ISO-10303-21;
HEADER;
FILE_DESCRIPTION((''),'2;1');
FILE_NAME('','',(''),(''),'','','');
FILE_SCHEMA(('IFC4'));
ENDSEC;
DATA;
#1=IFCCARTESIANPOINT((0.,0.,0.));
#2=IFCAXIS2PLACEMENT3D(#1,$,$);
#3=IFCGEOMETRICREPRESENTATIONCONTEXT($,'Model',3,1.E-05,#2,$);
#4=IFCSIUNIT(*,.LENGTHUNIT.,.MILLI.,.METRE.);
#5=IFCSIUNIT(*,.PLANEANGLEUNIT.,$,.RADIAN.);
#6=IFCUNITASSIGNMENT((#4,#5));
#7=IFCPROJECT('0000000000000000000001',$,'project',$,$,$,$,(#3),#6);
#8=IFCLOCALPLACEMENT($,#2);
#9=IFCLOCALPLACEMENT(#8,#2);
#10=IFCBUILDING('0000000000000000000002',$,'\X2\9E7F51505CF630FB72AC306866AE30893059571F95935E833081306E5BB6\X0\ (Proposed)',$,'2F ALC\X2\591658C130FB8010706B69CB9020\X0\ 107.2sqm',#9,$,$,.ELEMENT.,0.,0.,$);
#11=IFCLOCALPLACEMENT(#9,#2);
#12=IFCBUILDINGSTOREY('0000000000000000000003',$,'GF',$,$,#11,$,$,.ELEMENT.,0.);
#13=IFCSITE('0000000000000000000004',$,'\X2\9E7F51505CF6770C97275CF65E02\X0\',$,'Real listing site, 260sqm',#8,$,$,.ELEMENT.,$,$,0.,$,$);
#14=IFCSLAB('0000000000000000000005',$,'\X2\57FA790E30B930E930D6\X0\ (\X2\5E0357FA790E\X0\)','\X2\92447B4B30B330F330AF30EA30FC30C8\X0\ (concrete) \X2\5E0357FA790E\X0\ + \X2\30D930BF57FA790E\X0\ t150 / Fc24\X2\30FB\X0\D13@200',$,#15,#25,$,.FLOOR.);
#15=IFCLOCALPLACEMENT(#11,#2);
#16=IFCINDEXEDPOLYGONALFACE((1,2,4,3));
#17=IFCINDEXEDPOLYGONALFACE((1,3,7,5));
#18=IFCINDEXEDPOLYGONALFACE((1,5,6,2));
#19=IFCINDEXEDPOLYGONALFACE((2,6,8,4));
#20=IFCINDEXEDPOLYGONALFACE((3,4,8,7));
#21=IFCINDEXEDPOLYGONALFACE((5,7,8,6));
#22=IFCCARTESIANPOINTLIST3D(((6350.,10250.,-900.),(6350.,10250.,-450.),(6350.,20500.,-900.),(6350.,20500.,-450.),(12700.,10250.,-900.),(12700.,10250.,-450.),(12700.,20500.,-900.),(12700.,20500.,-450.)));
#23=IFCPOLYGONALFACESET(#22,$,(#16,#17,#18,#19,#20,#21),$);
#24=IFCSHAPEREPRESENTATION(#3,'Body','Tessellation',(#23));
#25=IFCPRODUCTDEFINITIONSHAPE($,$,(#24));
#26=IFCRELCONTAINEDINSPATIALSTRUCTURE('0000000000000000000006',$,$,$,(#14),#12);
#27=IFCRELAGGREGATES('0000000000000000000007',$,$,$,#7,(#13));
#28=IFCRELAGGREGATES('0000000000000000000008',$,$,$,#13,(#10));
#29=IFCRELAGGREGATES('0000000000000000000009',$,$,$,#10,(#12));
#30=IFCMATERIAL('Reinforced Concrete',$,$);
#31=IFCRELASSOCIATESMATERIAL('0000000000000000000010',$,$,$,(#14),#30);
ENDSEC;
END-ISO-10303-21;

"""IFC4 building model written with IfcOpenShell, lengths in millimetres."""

from ifc_helpers import new_model, si_unit, frame, frame_2d, origin, place, context, project, spatial, rectangle, extrude, material, element, save


model = new_model("IFC4")

# Units and contexts
model_context = context("Model", 3, precision=1e-05, world=origin())
ifc_project = project(units=[si_unit("LENGTHUNIT", "METRE", prefix="MILLI"), si_unit("PLANEANGLEUNIT", "RADIAN")], contexts=[model_context])

# Site, building, storey
site_placement = place(None, origin())
site = spatial("IfcSite", under=ifc_project, at=site_placement, Name="鹿児島県霧島市", ObjectType="Real listing site, 260sqm", CompositionType="ELEMENT", RefElevation=0.0)
building_placement = place(site_placement, origin())
building = spatial("IfcBuilding", under=site, at=building_placement, Name="鹿児島・犬と暮らす土間広めの家 (Proposed)", ObjectType="2F ALC外壁・耐火構造 107.2sqm", CompositionType="ELEMENT", ElevationOfRefHeight=0.0, ElevationOfTerrain=0.0)
storey_placement = place(building_placement, origin())
storey = spatial("IfcBuildingStorey", under=building, at=storey_placement, Name="GF", CompositionType="ELEMENT", Elevation=0.0)

# Slab
ifc_material_1 = material(Name="Reinforced Concrete")
slab_1_placement = place(storey_placement, frame((3175.0, 5125.0, -450.0)))
element("IfcSlab", 1, at=slab_1_placement, inside=storey, material=ifc_material_1, Name="基礎スラブ (布基礎)", Description="鉄筋コンクリート (concrete) 布基礎 + ベタ基礎 t150 / Fc24・D13@200", PredefinedType="FLOOR", context=model_context, shape_type="SweptSolid", body=[
    extrude(rectangle(XDim=6350.0, YDim=10250.0, at=frame_2d((3175.0, 5125.0))), frame((3175.0, 5125.0, -450.0)), (0.0, 0.0, 1.0), 450.0),
])

save(model, "model.ifc")
